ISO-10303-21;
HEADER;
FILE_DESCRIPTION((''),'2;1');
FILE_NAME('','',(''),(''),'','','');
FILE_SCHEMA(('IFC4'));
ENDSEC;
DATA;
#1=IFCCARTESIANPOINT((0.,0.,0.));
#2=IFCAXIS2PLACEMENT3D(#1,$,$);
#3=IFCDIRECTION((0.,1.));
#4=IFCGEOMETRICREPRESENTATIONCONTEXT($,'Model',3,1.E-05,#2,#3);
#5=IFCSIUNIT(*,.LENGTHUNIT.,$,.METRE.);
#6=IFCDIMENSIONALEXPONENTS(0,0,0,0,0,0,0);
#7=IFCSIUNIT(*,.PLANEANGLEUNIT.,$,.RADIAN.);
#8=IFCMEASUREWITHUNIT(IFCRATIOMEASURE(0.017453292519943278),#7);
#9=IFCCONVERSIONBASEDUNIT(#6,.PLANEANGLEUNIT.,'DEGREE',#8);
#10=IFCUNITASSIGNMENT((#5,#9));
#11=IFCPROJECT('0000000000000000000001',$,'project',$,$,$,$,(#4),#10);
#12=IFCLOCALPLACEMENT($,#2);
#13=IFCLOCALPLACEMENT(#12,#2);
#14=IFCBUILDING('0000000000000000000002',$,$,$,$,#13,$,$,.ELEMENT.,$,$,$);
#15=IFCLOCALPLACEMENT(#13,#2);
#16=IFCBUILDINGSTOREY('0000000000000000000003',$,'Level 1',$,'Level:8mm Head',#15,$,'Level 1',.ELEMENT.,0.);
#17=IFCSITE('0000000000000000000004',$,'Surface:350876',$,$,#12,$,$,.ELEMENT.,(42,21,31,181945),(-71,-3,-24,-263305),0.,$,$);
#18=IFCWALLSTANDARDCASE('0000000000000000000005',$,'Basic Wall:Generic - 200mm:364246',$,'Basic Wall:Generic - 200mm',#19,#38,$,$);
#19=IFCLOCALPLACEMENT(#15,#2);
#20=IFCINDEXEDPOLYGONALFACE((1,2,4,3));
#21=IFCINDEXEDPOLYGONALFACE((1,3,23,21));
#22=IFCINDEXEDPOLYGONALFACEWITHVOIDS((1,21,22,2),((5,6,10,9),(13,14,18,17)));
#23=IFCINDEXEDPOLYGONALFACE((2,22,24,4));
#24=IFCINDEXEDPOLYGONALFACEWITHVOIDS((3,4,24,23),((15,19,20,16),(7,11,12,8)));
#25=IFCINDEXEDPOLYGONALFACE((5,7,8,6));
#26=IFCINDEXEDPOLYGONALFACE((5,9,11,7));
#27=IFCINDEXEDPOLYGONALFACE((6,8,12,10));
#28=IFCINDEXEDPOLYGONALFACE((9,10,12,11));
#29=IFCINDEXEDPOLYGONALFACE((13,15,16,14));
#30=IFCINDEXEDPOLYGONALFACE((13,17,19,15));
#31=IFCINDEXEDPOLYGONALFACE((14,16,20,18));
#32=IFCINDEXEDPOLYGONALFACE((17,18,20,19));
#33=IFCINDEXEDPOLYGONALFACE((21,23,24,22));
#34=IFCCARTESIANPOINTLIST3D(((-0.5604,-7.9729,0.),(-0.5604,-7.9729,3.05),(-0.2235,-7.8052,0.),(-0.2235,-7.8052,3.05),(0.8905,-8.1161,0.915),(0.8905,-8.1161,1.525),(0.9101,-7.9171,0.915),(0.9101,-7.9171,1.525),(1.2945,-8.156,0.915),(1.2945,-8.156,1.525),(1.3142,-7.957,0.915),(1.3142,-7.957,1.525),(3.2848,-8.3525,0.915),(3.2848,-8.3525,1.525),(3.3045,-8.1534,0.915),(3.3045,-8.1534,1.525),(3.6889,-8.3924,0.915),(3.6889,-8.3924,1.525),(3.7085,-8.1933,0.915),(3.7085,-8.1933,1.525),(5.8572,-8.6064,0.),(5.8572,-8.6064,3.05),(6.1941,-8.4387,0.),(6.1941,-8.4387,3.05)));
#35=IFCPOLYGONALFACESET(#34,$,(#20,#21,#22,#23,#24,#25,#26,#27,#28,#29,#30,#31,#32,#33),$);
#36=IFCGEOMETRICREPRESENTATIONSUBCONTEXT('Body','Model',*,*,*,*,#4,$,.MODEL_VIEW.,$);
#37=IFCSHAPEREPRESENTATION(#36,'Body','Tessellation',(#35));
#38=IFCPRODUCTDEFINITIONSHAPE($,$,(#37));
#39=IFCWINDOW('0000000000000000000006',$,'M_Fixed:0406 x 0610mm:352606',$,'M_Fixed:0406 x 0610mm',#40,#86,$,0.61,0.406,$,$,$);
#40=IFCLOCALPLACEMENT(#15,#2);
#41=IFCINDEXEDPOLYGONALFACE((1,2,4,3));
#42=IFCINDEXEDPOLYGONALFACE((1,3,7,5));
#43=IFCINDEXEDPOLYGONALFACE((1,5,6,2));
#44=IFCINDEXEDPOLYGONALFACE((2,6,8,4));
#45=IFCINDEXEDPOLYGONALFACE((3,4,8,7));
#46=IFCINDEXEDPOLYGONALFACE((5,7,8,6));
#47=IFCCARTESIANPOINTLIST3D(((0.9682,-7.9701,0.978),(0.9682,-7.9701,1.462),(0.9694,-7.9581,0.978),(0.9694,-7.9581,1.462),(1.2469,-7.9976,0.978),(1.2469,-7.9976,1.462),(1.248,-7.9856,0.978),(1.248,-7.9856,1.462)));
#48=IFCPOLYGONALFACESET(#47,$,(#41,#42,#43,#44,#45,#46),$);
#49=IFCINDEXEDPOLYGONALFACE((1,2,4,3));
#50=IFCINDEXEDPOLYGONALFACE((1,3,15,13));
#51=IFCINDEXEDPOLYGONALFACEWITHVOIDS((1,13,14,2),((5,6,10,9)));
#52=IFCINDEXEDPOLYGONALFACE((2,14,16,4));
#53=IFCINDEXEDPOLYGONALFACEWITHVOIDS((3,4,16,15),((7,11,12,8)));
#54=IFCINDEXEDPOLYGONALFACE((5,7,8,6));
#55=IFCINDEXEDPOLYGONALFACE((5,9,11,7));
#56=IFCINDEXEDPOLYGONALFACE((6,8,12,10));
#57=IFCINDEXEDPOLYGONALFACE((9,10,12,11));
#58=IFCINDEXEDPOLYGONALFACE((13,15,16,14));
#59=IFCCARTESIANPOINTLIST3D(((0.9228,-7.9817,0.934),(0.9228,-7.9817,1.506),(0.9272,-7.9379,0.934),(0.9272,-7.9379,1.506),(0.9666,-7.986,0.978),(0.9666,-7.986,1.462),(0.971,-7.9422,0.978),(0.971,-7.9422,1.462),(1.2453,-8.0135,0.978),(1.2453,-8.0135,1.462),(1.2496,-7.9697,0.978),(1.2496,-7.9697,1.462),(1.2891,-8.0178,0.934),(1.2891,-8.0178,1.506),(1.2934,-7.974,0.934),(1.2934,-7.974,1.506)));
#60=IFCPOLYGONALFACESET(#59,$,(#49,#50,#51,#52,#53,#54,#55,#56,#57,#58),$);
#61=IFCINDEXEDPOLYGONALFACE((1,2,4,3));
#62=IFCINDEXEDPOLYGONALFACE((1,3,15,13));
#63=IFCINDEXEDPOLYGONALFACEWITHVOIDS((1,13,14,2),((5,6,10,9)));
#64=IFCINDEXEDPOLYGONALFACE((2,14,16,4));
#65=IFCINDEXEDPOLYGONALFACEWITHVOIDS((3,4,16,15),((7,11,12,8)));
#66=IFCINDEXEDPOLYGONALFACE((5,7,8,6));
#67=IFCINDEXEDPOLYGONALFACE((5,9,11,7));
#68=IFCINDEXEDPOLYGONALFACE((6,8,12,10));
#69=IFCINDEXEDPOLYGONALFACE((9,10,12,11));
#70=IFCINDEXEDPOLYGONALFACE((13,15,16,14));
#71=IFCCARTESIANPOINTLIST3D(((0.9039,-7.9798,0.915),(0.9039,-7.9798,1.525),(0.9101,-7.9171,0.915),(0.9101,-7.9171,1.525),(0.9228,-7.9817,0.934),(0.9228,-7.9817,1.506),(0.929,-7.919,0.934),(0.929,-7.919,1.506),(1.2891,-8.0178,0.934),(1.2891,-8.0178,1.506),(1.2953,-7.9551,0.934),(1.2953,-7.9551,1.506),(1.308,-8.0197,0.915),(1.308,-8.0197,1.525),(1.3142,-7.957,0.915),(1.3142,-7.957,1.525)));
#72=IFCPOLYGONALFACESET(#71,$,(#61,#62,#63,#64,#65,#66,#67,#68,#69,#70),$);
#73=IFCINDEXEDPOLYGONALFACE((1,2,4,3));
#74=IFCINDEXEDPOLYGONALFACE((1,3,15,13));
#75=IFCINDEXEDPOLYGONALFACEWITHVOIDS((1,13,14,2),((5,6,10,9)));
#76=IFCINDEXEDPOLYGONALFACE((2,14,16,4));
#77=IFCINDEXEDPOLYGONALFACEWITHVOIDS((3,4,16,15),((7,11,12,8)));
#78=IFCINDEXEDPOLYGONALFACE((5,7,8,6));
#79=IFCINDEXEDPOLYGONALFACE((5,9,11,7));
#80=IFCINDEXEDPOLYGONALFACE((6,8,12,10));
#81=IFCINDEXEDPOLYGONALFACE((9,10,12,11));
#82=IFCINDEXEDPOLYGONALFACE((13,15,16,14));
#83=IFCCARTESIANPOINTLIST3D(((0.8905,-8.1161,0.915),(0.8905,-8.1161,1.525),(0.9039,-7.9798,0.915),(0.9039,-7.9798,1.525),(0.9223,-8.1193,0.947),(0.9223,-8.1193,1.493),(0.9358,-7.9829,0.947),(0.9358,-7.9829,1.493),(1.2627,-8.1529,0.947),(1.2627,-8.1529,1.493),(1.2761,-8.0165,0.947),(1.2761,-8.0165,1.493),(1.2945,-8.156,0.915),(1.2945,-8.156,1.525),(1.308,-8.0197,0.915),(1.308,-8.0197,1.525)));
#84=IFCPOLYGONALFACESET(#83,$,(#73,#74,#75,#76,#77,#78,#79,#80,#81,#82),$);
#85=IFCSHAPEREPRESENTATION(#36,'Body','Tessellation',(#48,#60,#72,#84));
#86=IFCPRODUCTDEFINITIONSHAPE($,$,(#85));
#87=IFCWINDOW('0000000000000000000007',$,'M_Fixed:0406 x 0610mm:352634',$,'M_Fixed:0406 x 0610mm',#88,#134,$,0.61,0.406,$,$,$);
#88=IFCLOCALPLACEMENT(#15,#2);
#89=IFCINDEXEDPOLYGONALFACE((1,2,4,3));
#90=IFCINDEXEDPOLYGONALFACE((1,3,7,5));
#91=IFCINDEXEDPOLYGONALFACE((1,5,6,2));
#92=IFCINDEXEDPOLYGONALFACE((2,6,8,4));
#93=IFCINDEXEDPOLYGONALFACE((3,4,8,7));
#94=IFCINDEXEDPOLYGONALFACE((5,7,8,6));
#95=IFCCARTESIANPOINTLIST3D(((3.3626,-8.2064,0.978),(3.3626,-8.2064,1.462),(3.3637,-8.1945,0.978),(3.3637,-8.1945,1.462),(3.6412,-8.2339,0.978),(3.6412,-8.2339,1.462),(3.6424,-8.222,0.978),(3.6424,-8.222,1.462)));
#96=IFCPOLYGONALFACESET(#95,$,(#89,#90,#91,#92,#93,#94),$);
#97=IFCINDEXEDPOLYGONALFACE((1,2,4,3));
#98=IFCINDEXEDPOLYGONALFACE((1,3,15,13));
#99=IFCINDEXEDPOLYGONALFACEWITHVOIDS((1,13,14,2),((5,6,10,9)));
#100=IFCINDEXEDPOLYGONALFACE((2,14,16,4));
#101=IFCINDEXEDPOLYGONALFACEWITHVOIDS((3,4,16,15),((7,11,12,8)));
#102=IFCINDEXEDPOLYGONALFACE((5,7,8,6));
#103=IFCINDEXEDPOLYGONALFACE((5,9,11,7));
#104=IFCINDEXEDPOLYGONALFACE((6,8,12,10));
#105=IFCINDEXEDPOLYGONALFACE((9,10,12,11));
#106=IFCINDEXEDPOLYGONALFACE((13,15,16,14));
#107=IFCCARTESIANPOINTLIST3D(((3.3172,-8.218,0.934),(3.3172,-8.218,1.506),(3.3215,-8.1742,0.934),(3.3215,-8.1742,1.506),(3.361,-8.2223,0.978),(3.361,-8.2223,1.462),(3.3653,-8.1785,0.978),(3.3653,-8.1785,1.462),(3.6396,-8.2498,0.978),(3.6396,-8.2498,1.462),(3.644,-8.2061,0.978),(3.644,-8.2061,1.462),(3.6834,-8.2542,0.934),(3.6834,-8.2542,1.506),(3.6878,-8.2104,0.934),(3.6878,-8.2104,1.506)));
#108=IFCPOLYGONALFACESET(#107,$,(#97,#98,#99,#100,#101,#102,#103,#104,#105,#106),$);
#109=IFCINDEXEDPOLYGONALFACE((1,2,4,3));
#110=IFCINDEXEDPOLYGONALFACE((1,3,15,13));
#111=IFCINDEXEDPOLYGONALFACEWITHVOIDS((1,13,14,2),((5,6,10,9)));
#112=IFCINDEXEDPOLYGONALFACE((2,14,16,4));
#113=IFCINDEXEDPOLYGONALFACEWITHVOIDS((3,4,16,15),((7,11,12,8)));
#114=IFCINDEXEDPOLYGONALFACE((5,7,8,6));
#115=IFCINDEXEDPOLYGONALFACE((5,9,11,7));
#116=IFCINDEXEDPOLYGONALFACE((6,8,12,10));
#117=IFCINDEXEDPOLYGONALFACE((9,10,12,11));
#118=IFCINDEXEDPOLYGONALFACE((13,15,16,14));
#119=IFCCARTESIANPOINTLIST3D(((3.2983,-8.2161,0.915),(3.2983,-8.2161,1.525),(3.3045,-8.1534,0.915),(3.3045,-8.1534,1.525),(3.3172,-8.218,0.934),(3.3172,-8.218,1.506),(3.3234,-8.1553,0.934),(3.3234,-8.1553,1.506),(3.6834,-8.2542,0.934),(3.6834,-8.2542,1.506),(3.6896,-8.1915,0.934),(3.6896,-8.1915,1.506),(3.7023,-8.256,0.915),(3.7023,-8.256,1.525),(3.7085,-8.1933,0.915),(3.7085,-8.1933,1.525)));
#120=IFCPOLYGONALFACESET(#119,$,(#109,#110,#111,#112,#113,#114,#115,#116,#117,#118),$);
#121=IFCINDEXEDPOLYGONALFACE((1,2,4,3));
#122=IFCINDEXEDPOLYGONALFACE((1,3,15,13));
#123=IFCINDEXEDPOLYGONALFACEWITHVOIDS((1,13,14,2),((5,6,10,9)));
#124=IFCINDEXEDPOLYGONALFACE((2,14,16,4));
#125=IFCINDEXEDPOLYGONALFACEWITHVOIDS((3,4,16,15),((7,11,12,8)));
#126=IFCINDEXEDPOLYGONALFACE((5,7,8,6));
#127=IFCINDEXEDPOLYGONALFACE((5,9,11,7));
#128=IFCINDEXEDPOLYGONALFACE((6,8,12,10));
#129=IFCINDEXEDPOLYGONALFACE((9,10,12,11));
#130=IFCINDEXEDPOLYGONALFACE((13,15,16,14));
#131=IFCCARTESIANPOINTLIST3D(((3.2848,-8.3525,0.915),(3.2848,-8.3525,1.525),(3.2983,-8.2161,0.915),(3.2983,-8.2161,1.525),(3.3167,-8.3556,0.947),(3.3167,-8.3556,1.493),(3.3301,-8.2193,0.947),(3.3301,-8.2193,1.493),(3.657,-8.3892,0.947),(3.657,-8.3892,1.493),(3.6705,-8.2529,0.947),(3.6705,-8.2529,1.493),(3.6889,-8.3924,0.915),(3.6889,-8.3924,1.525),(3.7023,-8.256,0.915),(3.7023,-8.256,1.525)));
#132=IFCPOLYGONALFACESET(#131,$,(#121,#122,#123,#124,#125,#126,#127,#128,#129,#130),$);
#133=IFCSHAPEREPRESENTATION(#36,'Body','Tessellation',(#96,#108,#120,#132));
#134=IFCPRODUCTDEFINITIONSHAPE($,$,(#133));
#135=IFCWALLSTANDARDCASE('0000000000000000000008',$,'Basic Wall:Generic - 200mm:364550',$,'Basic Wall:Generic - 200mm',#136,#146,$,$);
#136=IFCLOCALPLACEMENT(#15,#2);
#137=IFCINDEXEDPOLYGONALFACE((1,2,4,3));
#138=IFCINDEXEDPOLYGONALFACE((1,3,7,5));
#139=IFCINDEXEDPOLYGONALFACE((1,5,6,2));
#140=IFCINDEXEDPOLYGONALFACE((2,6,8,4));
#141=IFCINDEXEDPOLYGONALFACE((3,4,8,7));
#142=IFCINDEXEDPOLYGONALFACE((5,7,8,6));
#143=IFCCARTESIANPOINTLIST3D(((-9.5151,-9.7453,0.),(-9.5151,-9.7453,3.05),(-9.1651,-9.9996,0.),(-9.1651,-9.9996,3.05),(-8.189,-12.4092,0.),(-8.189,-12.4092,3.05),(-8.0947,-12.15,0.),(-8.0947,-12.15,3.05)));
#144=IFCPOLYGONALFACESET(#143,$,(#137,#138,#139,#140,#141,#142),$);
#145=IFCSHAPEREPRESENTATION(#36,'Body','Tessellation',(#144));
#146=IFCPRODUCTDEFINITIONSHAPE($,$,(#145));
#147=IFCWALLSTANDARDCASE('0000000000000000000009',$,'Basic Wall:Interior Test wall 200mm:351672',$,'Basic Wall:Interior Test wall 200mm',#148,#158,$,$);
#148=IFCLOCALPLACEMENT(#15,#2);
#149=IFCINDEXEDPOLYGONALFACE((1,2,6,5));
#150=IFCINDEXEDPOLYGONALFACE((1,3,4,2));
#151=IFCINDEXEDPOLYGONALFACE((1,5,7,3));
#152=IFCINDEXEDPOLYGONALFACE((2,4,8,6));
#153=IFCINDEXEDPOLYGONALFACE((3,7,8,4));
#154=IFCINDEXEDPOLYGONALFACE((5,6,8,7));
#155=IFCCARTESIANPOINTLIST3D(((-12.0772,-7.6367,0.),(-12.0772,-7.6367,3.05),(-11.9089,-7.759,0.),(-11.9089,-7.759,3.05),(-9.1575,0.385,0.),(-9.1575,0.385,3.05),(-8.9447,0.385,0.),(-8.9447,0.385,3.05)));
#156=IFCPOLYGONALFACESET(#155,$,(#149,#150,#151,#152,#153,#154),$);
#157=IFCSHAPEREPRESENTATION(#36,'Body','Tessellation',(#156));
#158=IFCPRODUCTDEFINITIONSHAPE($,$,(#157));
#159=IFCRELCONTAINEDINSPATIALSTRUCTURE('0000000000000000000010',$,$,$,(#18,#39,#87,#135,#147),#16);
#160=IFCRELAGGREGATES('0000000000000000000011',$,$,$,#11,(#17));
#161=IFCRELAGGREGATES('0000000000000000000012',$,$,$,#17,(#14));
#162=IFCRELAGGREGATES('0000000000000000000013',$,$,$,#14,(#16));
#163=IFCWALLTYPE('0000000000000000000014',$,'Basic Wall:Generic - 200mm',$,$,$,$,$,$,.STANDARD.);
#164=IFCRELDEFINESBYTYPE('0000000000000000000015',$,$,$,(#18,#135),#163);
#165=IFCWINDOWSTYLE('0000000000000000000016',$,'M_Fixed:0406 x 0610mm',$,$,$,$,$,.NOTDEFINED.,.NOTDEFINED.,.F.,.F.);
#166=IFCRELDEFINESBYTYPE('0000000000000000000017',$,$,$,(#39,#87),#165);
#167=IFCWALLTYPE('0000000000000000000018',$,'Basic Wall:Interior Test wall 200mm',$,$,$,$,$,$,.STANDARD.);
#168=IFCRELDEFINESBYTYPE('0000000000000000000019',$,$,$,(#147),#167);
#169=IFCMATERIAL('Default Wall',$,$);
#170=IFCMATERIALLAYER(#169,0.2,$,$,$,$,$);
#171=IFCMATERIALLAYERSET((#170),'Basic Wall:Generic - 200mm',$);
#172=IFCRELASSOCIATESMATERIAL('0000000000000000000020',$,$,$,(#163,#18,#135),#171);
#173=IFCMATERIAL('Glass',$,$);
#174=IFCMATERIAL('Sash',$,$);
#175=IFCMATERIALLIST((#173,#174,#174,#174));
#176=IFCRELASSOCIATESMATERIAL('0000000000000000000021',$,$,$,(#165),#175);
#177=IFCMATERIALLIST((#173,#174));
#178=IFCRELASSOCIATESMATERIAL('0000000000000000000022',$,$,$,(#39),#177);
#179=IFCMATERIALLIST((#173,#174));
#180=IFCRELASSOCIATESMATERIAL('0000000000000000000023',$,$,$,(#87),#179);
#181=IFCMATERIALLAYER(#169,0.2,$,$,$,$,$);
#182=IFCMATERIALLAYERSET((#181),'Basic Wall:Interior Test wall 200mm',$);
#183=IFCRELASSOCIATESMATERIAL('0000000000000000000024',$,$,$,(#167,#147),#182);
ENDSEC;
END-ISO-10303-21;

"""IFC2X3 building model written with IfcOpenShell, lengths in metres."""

from ifc_helpers import new_model, entity, si_unit, converted_unit, direction, frame, frame_2d, origin, place, context, subcontext, project, spatial, polyline, rectangle, outline, extrude, clip, bounded_halfspace, source, transform, mapped, material, material_list, layer, layer_set, layer_usage, type_object, type_shapes, element, fill, save


model = new_model("IFC2X3")

# Units and contexts
model_context = context("Model", 3, precision=1e-05, world=origin(), true_north=direction((0.0, 1.0)))
body_context = subcontext(model_context, "Body", "Model", "MODEL_VIEW")
ifc_project = project(units=[si_unit("LENGTHUNIT", "METRE"), converted_unit("PLANEANGLEUNIT", "DEGREE", entity("IfcRatioMeasure", 0.017453292519943278), si_unit("PLANEANGLEUNIT", "RADIAN"), dimensions=[0, 0, 0, 0, 0, 0, 0])], contexts=[model_context])

# Site, building, storey
site_placement = place(None, origin())
site = spatial("IfcSite", under=ifc_project, at=site_placement, Name="Surface:350876", CompositionType="ELEMENT", RefLatitude=(42, 21, 31, 181945), RefLongitude=(-71, -3, -24, -263305), RefElevation=0.0)
building_placement = place(site_placement, origin())
building = spatial("IfcBuilding", under=site, at=building_placement, CompositionType="ELEMENT")
storey_placement = place(building_placement, origin())
storey = spatial("IfcBuildingStorey", under=building, at=storey_placement, Name="Level 1", ObjectType="Level:8mm Head", LongName="Level 1", CompositionType="ELEMENT", Elevation=0.0)

# Shared definitions
ifc_material_1 = material(Name="Default Wall")
ifc_layer_1 = layer(ifc_material_1, 0.2)
ifc_layer_set_1 = layer_set([ifc_layer_1], Name="Basic Wall:Generic - 200mm")
wall_type_1 = type_object("IfcWallType", Name="Basic Wall:Generic - 200mm", PredefinedType="STANDARD", material=ifc_layer_set_1)
ifc_material_2 = material(Name="Glass")
ifc_material_3 = material(Name="Sash")
ifc_material_list_1 = material_list([ifc_material_2, ifc_material_3, ifc_material_3, ifc_material_3])
window_style = type_object("IfcWindowStyle", Name="M_Fixed:0406 x 0610mm", ConstructionType="NOTDEFINED", OperationType="NOTDEFINED", ParameterTakesPrecedence=False, Sizeable=False, material=ifc_material_list_1)
shared_shape_1 = source(origin(), body_context, "Body", "SweptSolid", [
    extrude(rectangle(XDim=0.012, YDim=0.28, at=frame_2d((0.0, 0.0), x_axis=(1.0, 0.0))), frame((0.203, 0.159, 0.063), z_axis=(0.0, 0.0, 1.0), x_axis=(0.0, -1.0, 0.0)), (0.0, 0.0, 1.0), 0.484),
    extrude(outline(polyline([(-0.184, -0.286), (0.184, -0.286), (0.184, 0.286), (-0.184, 0.286), (-0.184, -0.286)]), holes=[polyline([(-0.14, -0.242), (-0.14, 0.242), (0.14, 0.242), (0.14, -0.242), (-0.14, -0.242)])]), frame((0.203, 0.137, 0.305), z_axis=(0.0, 1.0, 0.0), x_axis=(1.0, 0.0, 0.0)), (0.0, 0.0, 1.0), 0.044),
    extrude(outline(polyline([(-0.203, -0.305), (0.203, -0.305), (0.203, 0.305), (-0.203, 0.305), (-0.203, -0.305)]), holes=[polyline([(-0.184, -0.286), (-0.184, 0.286), (0.184, 0.286), (0.184, -0.286), (-0.184, -0.286)])]), frame((0.203, 0.137, 0.305), z_axis=(0.0, 1.0, 0.0), x_axis=(1.0, 0.0, 0.0)), (0.0, 0.0, 1.0), 0.063),
    extrude(outline(polyline([(-0.203, -0.305), (0.203, -0.305), (0.203, 0.305), (-0.203, 0.305), (-0.203, -0.305)]), holes=[polyline([(-0.171, -0.273), (-0.171, 0.273), (0.171, 0.273), (0.171, -0.273), (-0.171, -0.273)])]), frame((0.203, 0.0, 0.305), z_axis=(0.0, 1.0, 0.0), x_axis=(1.0, 0.0, 0.0)), (0.0, 0.0, 1.0), 0.137),
])
type_shapes(window_style, [shared_shape_1])

# Wall, openings, windows
ifc_layer_usage_1 = layer_usage(ifc_layer_set_1, "AXIS2", "NEGATIVE", 0.1)
wall_1_placement = place(storey_placement, frame((-0.5506, -7.8734, 0.0), z_axis=(0.0, 0.0, 1.0), x_axis=(0.995163, -0.098237, 0.0)))
wall_1 = element("IfcWallStandardCase", 1, at=wall_1_placement, inside=storey, type_object=wall_type_1, material=ifc_layer_usage_1, Name="Basic Wall:Generic - 200mm:364246", ObjectType="Basic Wall:Generic - 200mm", context=body_context, shape_type="SweptSolid", body=[
    extrude(outline(polyline([(6.4488, -0.1), (6.7676, 0.1), (6.3913, 0.1), (6.347, 0.1), (0.3188, 0.1), (0.0, -0.1), (6.4488, -0.1)])), origin(), (0.0, 0.0, 1.0), 3.05),
])
opening_1_placement = place(wall_1_placement, frame((1.4579, -0.1, 0.915)))
opening_1 = element("IfcOpeningElement", 2, at=opening_1_placement, cuts=wall_1, ObjectType="Opening", context=body_context, shape_type="SweptSolid", body=[
    extrude(rectangle(XDim=0.61, YDim=0.406, at=frame_2d((0.305, 0.203), x_axis=(1.0, 0.0))), frame((0.0, 0.0, 0.0), z_axis=(0.0, 1.0, 0.0), x_axis=(0.0, 0.0, 1.0)), (0.0, 0.0, 1.0), 0.2),
])
opening_2_placement = place(wall_1_placement, frame((3.8639, -0.1, 0.915)))
opening_2 = element("IfcOpeningElement", 3, at=opening_2_placement, cuts=wall_1, ObjectType="Opening", context=body_context, shape_type="SweptSolid", body=[
    extrude(rectangle(XDim=0.61, YDim=0.406, at=frame_2d((0.305, 0.203), x_axis=(1.0, 0.0))), frame((0.0, 0.0, 0.0), z_axis=(0.0, 1.0, 0.0), x_axis=(0.0, 0.0, 1.0)), (0.0, 0.0, 1.0), 0.2),
])
ifc_material_list_2 = material_list([ifc_material_2, ifc_material_3])
window_1_placement = place(opening_1_placement, origin())
window_1 = element("IfcWindow", 4, at=window_1_placement, inside=storey, type_object=window_style, material=ifc_material_list_2, Name="M_Fixed:0406 x 0610mm:352606", ObjectType="M_Fixed:0406 x 0610mm", OverallHeight=0.61, OverallWidth=0.406, context=body_context, shape_type="MappedRepresentation", body=[
    mapped(shared_shape_1, transform((0.0, 0.0, 0.0), scale=1.0)),
])
fill(opening_1, window_1)
ifc_material_list_3 = material_list([ifc_material_2, ifc_material_3])
window_2_placement = place(opening_2_placement, origin())
window_2 = element("IfcWindow", 5, at=window_2_placement, inside=storey, type_object=window_style, material=ifc_material_list_3, Name="M_Fixed:0406 x 0610mm:352634", ObjectType="M_Fixed:0406 x 0610mm", OverallHeight=0.61, OverallWidth=0.406, context=body_context, shape_type="MappedRepresentation", body=[
    mapped(shared_shape_1, transform((0.0, 0.0, 0.0), scale=1.0)),
])
fill(opening_2, window_2)

# Walls
ifc_layer_usage_2 = layer_usage(ifc_layer_set_1, "AXIS2", "NEGATIVE", 0.1)
wall_2_placement = place(storey_placement, frame((-9.4256, -9.7008, 0.0), z_axis=(0.0, 0.0, 1.0), x_axis=(0.44563, -0.895217, 0.0)))
element("IfcWallStandardCase", 6, at=wall_2_placement, inside=storey, type_object=wall_type_1, material=ifc_layer_usage_2, Name="Basic Wall:Generic - 200mm:364550", ObjectType="Basic Wall:Generic - 200mm", context=body_context, shape_type="SweptSolid", body=[
    extrude(outline(polyline([(2.9757, -0.1), (2.7857, 0.1), (0.3836, 0.1), (0.0, -0.1), (2.9757, -0.1)])), origin(), (0.0, 0.0, 1.0), 3.05),
])
ifc_layer_2 = layer(ifc_material_1, 0.2)
ifc_layer_set_2 = layer_set([ifc_layer_2], Name="Basic Wall:Interior Test wall 200mm")
ifc_layer_usage_3 = layer_usage(ifc_layer_set_2, "AXIS2", "NEGATIVE", 0.1)
wall_type_2 = type_object("IfcWallType", Name="Basic Wall:Interior Test wall 200mm", PredefinedType="STANDARD", material=ifc_layer_set_2)
wall_3_placement = place(storey_placement, frame((-12.0028, -7.7248, 0.0), z_axis=(0.0, 0.0, 1.0), x_axis=(0.34202, 0.939693, 0.0)))
element("IfcWallStandardCase", 7, at=wall_3_placement, inside=storey, type_object=wall_type_2, material=ifc_layer_usage_3, Name="Basic Wall:Interior Test wall 200mm:351672", ObjectType="Basic Wall:Interior Test wall 200mm", context=body_context, shape_type="Clipping", body=[
    clip(extrude(outline(polyline([(8.6666, -0.1), (8.5938, 0.1), (0.0573, 0.1), (0.0, -0.1), (8.4538, -0.1), (8.6666, -0.1)])), origin(), (0.0, 0.0, 1.0), 3.05), bounded_halfspace(frame((0.0, -0.1, 3.05), z_axis=(0.0, 0.0, -1.0), x_axis=(0.992546, 0.121869, 0.0)), True, frame((0.0, -0.1, 3.05)), polyline([(0.0, 0.0), (8.4538, 0.0), (8.6666, 0.0), (8.5938, 0.2), (0.0573, 0.2), (0.0, 0.0)]))),
])

save(model, "model.ifc")
